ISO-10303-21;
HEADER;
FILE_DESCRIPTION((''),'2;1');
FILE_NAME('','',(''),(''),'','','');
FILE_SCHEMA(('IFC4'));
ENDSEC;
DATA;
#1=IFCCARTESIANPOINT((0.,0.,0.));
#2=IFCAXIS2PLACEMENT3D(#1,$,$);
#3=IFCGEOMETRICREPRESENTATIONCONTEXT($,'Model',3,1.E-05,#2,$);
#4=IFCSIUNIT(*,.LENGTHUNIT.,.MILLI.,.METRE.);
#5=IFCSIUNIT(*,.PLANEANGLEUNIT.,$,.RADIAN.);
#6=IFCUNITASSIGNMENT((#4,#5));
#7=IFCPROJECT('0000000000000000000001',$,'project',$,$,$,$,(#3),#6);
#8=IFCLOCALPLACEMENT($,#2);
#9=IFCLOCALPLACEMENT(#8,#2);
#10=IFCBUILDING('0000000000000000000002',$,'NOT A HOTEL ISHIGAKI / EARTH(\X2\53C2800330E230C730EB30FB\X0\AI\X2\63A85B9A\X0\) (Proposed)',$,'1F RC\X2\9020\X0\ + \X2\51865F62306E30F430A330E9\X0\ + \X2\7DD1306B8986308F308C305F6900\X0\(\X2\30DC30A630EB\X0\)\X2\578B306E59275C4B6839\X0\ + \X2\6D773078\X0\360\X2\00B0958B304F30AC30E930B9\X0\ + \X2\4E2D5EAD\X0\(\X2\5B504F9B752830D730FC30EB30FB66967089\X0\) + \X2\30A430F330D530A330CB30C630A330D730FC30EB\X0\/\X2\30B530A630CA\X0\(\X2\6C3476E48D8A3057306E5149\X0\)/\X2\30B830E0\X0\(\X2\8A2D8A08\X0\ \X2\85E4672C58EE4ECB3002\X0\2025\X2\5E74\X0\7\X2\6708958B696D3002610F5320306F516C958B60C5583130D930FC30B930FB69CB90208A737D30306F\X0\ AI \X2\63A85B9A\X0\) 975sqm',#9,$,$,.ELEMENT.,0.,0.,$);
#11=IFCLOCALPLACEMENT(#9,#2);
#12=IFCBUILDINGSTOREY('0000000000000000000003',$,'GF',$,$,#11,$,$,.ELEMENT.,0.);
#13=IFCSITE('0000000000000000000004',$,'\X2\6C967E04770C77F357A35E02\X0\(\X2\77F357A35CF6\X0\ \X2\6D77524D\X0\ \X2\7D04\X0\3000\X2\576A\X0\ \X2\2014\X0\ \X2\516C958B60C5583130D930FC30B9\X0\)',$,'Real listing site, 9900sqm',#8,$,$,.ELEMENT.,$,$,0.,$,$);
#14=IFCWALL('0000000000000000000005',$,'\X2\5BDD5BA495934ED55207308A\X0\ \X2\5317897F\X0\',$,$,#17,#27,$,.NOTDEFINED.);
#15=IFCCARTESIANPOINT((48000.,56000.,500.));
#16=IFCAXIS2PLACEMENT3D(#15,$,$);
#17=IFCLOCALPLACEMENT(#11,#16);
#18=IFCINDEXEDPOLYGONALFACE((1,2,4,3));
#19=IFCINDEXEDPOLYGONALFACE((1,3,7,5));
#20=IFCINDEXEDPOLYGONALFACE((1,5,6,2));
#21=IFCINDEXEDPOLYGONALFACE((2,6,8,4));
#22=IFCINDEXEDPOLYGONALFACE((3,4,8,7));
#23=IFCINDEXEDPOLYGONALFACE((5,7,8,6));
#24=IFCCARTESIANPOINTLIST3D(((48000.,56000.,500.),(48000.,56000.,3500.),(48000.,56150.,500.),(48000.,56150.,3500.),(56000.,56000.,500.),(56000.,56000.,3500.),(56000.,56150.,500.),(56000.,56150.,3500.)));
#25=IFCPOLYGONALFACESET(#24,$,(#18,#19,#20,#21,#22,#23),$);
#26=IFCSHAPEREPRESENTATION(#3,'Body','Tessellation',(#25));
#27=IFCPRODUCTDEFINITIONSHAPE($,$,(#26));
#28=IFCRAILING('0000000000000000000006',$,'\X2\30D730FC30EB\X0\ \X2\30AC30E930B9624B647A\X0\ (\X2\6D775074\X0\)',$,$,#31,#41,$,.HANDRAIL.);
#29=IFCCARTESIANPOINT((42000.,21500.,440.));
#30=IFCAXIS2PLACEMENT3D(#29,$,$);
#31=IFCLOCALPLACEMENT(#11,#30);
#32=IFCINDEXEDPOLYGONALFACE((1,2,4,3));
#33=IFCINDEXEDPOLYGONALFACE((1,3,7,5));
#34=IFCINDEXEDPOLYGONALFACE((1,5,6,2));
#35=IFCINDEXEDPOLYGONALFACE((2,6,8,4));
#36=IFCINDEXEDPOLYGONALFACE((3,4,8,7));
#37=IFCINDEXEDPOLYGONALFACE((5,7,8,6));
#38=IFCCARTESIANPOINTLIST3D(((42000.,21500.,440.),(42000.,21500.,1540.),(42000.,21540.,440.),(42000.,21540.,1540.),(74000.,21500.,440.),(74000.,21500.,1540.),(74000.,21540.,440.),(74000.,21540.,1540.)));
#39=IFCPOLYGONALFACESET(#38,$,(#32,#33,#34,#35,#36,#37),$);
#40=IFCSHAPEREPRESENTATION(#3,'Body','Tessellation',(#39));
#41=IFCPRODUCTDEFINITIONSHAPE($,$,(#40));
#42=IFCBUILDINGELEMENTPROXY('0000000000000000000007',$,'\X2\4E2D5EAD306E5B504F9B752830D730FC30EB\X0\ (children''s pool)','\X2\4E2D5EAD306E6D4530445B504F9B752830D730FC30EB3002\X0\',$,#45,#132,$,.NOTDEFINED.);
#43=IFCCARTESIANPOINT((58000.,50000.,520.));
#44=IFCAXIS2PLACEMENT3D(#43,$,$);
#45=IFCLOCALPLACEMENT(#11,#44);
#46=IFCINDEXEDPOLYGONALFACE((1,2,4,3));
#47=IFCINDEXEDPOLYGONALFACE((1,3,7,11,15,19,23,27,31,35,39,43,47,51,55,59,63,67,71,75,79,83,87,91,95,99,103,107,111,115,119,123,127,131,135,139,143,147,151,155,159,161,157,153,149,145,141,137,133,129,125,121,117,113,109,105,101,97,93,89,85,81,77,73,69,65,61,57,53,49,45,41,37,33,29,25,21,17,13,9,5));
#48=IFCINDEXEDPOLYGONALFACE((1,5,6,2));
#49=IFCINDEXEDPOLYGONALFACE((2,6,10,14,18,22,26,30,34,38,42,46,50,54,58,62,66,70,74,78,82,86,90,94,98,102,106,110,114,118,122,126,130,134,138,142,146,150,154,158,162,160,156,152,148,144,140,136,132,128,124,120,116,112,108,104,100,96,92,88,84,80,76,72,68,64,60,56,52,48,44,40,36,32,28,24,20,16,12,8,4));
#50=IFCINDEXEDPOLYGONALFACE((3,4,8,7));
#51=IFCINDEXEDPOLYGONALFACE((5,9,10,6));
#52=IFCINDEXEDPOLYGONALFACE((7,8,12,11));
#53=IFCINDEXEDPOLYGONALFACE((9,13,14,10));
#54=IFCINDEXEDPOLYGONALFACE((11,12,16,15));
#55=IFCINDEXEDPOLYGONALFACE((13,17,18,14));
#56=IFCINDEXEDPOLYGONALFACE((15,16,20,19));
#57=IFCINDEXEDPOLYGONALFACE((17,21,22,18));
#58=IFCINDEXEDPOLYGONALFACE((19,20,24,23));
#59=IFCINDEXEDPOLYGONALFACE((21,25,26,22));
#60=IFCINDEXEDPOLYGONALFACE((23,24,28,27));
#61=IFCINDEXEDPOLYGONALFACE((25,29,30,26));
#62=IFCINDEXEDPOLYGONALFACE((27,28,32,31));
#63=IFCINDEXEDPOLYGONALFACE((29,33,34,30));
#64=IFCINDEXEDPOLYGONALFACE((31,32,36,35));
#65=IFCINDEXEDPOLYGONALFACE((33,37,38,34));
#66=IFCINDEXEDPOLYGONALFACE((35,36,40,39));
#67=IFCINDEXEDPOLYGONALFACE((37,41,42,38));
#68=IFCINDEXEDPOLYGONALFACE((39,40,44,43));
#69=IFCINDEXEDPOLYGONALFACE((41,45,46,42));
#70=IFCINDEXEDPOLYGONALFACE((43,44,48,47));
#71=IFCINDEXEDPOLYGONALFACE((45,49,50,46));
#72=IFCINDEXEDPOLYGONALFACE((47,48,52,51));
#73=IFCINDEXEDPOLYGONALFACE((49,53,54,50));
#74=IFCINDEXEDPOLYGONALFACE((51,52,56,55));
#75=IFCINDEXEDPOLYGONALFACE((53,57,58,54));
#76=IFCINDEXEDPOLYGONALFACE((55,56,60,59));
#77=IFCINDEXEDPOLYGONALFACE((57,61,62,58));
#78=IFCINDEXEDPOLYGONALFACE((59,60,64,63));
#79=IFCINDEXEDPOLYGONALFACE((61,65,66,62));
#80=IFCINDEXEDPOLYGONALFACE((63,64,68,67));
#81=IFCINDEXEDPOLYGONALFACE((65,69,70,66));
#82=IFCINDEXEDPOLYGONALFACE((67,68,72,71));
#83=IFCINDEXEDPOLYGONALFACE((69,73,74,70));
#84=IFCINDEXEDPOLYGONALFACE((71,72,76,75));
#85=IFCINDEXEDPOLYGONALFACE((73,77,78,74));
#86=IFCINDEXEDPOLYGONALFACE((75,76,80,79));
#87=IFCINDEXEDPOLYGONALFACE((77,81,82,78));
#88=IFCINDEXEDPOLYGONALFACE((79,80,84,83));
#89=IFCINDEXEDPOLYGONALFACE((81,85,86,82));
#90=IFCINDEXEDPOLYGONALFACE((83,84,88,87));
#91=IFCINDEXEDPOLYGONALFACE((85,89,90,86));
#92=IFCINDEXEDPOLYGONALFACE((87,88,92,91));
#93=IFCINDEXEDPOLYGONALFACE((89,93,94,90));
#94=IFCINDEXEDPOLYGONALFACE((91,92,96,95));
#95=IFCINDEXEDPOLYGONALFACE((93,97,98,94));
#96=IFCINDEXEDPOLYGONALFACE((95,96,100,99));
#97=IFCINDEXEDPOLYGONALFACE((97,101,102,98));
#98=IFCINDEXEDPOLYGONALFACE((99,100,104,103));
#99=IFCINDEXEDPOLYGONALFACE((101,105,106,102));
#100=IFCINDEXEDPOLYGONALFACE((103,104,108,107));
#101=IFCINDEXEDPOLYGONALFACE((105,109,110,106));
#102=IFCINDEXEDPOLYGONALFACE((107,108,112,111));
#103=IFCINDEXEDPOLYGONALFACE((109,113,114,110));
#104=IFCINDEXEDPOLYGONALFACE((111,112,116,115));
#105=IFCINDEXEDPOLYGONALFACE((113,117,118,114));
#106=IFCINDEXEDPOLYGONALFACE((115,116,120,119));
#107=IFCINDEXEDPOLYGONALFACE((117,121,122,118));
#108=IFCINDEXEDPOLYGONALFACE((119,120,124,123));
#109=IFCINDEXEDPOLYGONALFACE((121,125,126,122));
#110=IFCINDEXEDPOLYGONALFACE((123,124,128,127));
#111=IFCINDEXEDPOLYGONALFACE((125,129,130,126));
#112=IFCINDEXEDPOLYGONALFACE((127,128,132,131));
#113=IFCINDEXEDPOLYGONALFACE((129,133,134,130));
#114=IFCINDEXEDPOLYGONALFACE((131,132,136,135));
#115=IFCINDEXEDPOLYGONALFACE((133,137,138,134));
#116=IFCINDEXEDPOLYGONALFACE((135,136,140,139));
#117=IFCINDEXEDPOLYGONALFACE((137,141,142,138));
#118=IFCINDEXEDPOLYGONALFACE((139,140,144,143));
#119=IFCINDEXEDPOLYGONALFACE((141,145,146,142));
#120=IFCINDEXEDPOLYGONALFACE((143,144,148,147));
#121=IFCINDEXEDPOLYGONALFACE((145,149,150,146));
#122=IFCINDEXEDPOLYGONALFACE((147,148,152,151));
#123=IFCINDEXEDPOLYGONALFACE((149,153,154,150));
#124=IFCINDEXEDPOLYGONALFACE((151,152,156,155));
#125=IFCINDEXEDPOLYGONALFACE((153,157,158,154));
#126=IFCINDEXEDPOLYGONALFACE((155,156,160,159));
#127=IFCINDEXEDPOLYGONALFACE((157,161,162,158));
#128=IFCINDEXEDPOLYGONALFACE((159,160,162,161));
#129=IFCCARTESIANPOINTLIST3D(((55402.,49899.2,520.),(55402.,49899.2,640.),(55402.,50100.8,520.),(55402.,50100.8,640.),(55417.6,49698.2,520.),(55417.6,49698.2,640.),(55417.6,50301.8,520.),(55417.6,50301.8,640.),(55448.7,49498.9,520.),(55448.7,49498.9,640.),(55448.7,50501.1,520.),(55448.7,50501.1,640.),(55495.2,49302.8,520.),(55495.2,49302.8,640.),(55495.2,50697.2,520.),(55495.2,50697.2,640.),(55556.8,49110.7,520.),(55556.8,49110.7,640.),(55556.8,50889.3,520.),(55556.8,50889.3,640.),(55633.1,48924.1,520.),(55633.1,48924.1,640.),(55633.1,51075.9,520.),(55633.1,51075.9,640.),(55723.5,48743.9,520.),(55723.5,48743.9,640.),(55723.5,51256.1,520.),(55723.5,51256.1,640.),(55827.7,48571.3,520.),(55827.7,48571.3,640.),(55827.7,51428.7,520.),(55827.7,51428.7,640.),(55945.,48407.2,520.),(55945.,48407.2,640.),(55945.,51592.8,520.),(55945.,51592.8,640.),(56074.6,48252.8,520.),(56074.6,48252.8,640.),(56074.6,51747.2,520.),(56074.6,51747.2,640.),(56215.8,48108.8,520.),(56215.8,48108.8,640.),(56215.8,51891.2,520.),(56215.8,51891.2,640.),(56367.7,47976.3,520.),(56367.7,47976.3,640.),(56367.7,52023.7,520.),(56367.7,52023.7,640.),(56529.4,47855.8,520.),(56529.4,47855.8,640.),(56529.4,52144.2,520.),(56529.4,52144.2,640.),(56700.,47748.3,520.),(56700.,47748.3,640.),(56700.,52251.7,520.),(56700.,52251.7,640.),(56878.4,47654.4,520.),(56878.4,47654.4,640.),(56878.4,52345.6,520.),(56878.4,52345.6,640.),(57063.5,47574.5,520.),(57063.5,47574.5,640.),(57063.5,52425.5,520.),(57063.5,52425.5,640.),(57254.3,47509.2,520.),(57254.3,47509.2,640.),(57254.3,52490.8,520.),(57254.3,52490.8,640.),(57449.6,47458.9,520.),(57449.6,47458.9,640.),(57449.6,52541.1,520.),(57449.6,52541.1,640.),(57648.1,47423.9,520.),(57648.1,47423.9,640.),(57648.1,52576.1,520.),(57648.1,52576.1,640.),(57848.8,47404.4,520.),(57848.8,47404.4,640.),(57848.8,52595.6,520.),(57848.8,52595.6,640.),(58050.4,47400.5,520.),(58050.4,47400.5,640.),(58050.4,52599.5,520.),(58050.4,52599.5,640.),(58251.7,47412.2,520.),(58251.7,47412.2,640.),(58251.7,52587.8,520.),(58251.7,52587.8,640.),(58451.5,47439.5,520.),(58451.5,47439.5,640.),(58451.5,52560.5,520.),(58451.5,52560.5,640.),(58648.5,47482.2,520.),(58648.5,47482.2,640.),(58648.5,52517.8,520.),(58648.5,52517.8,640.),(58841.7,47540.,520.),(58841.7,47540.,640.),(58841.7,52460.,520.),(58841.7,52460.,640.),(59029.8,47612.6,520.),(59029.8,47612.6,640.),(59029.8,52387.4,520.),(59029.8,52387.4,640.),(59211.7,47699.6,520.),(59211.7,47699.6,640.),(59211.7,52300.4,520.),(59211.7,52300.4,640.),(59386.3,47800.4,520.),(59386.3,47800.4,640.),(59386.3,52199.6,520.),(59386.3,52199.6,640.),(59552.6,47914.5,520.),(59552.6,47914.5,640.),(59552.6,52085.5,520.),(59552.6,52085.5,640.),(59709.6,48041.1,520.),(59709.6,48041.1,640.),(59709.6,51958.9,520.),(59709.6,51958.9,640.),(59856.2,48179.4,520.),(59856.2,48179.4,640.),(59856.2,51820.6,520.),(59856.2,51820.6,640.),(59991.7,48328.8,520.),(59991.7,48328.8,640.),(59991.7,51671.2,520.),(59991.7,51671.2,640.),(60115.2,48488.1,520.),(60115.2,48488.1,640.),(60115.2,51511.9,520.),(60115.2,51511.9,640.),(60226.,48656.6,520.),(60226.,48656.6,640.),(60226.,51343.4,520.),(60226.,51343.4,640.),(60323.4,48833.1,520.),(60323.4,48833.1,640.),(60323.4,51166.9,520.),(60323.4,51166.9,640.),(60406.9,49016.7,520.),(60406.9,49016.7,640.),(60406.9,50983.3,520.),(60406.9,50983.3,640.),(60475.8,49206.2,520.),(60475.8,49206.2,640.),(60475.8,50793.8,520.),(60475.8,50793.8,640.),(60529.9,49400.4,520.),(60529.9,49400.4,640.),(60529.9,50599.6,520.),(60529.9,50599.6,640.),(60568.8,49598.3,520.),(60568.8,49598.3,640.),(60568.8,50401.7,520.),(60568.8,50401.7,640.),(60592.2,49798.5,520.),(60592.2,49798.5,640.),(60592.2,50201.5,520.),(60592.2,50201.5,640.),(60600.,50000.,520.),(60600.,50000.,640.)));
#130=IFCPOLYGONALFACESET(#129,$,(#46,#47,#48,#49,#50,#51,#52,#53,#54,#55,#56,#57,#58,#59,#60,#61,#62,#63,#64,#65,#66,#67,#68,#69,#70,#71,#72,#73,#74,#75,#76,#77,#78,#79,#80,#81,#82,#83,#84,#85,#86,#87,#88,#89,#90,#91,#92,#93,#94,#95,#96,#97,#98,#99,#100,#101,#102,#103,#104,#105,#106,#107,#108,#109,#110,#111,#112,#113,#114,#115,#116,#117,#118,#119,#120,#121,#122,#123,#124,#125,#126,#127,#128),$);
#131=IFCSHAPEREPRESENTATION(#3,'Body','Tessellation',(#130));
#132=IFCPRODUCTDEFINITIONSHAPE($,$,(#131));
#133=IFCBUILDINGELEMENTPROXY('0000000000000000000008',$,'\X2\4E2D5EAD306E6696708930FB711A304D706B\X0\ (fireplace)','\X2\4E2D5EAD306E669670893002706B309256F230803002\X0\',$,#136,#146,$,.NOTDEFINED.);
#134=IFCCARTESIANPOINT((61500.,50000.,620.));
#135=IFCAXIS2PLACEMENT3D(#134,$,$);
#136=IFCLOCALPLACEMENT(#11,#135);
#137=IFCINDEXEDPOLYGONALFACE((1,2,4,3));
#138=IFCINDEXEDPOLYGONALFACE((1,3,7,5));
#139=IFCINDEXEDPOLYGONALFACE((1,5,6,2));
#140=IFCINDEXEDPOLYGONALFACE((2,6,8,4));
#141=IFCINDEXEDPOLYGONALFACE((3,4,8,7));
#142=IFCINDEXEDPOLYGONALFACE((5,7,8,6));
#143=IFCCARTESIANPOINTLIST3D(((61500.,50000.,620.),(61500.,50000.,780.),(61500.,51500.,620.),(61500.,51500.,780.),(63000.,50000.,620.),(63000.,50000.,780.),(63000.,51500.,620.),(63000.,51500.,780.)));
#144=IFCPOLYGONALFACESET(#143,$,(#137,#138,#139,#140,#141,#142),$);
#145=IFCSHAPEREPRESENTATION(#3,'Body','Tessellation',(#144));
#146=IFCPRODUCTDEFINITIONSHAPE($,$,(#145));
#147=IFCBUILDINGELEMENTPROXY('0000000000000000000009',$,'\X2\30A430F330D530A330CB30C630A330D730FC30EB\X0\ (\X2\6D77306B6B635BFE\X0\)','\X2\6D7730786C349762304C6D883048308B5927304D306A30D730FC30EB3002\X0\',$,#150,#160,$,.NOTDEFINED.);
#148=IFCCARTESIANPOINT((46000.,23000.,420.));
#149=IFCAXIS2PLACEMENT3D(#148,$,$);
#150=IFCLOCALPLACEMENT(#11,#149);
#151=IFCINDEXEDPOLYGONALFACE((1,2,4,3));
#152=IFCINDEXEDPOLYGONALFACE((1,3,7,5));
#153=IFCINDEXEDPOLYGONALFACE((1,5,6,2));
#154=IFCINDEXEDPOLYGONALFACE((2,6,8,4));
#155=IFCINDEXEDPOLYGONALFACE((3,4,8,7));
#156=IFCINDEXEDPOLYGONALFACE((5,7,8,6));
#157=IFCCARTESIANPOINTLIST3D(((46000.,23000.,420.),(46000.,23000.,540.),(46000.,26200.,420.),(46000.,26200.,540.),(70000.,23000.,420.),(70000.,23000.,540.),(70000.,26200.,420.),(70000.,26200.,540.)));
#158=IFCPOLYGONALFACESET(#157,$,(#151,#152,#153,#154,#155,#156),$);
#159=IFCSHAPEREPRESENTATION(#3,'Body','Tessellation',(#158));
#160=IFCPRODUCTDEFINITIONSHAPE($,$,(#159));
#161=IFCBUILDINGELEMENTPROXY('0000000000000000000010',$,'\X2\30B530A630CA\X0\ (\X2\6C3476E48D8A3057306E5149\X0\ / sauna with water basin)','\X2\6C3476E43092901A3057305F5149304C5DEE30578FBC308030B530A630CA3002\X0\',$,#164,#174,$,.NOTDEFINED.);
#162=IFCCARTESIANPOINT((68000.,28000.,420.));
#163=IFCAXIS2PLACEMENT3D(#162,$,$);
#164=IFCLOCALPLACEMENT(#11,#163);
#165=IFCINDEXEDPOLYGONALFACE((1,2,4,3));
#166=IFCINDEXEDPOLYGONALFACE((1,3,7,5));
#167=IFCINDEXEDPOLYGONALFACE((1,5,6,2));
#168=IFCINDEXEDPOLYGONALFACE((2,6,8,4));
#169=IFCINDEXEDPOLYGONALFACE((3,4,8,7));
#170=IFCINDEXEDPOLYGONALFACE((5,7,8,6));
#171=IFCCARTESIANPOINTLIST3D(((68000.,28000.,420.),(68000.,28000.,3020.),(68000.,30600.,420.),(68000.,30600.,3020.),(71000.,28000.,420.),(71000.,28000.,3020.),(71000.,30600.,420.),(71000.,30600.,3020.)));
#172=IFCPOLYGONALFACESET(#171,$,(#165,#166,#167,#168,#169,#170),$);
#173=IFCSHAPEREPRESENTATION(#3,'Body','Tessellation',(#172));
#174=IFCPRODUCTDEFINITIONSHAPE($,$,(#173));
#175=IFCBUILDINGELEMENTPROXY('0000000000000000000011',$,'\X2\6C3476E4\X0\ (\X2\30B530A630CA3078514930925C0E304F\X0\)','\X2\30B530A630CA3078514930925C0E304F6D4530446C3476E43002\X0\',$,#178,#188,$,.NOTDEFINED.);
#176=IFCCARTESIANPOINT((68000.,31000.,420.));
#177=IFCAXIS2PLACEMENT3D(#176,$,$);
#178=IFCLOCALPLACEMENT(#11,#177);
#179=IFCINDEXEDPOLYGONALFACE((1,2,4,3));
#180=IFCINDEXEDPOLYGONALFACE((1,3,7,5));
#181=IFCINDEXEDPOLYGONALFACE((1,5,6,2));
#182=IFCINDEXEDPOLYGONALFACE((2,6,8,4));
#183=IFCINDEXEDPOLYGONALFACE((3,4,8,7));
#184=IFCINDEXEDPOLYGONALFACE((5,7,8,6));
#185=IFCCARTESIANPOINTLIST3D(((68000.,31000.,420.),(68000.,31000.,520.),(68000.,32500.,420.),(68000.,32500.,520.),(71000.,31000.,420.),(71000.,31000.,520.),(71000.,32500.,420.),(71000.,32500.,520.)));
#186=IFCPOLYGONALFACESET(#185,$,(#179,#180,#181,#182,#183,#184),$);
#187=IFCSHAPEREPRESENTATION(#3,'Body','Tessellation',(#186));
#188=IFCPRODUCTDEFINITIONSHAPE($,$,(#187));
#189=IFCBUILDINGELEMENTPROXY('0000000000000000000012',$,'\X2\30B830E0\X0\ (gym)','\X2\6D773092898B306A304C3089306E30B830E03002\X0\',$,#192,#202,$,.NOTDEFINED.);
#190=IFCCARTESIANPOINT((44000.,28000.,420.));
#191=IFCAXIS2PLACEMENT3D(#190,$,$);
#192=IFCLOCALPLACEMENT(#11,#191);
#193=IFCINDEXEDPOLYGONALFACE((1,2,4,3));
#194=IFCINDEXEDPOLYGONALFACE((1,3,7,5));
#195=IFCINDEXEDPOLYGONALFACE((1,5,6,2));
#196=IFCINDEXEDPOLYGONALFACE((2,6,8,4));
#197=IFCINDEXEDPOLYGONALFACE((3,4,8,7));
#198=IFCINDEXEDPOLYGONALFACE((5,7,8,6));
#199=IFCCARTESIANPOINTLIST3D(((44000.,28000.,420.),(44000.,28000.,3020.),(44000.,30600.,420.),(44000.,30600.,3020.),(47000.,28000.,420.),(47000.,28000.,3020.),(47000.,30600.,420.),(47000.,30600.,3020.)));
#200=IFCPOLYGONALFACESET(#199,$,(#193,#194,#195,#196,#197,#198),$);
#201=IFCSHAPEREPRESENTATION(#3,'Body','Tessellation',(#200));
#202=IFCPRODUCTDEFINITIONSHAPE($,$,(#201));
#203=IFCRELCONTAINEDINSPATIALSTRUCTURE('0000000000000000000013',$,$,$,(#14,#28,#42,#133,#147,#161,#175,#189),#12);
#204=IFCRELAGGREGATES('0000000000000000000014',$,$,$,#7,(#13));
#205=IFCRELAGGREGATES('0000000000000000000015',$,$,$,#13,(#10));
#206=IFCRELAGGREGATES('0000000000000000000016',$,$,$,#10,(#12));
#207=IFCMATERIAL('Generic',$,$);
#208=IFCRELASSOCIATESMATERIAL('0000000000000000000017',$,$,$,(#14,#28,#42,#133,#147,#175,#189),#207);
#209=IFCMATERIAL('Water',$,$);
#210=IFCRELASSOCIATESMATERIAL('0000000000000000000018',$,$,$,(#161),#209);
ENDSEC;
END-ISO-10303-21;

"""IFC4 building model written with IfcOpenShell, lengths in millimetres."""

from ifc_helpers import new_model, si_unit, frame, frame_2d, origin, origin_2d, place, context, project, spatial, rectangle, circle, extrude, material, element, save


model = new_model("IFC4")

# Units and contexts
model_context = context("Model", 3, precision=1e-05, world=origin())
ifc_project = project(units=[si_unit("LENGTHUNIT", "METRE", prefix="MILLI"), si_unit("PLANEANGLEUNIT", "RADIAN")], contexts=[model_context])

# Site, building, storey
site_placement = place(None, origin())
site = spatial("IfcSite", under=ifc_project, at=site_placement, Name="沖縄県石垣市(石垣島 海前 約3000坪 — 公開情報ベース)", ObjectType="Real listing site, 9900sqm", CompositionType="ELEMENT", RefElevation=0.0)
building_placement = place(site_placement, origin())
building = spatial("IfcBuilding", under=site, at=building_placement, Name="NOT A HOTEL ISHIGAKI / EARTH(参考モデル・AI推定) (Proposed)", ObjectType="1F RC造 + 円形のヴィラ + 緑に覆われた椀(ボウル)型の大屋根 + 海へ360°開くガラス + 中庭(子供用プール・暖炉) + インフィニティプール/サウナ(水盤越しの光)/ジム(設計 藤本壮介。2025年7月開業。意匠は公開情報ベース・構造詳細は AI 推定) 975sqm", CompositionType="ELEMENT", ElevationOfRefHeight=0.0, ElevationOfTerrain=0.0)
storey_placement = place(building_placement, origin())
storey = spatial("IfcBuildingStorey", under=building, at=storey_placement, Name="GF", CompositionType="ELEMENT", Elevation=0.0)

# Shared definitions
ifc_material_1 = material(Name="Generic")

# Wall
wall_1_placement = place(storey_placement, frame((48000.0, 56000.0, 500.0)))
element("IfcWall", 1, at=wall_1_placement, inside=storey, material=ifc_material_1, Name="寝室間仕切り 北西", PredefinedType="NOTDEFINED", context=model_context, shape_type="SweptSolid", body=[
    extrude(rectangle(XDim=8000.0, YDim=150.0, at=frame_2d((4000.0, 75.0))), frame((48000.0, 56000.0, 500.0)), (0.0, 0.0, 1.0), 3000.0),
])

# Railing
railing_placement = place(storey_placement, frame((42000.0, 21500.0, 440.0)))
element("IfcRailing", 2, at=railing_placement, inside=storey, material=ifc_material_1, Name="プール ガラス手摺 (海側)", PredefinedType="HANDRAIL", context=model_context, shape_type="SweptSolid", body=[
    extrude(rectangle(XDim=32000.0, YDim=40.0, at=frame_2d((16000.0, 20.0))), frame((42000.0, 21500.0, 440.0)), (0.0, 0.0, 1.0), 1100.0),
])

# Building element proxies
proxy_1_placement = place(storey_placement, frame((58000.0, 50000.0, 520.0)))
element("IfcBuildingElementProxy", 3, at=proxy_1_placement, inside=storey, material=ifc_material_1, Name="中庭の子供用プール (children's pool)", Description="中庭の浅い子供用プール。", PredefinedType="NOTDEFINED", context=model_context, shape_type="SweptSolid", body=[
    extrude(circle(Radius=2600.0, at=origin_2d()), frame((58000.0, 50000.0, 520.0)), (0.0, 0.0, 1.0), 120.0),
])
proxy_2_placement = place(storey_placement, frame((61500.0, 50000.0, 620.0)))
element("IfcBuildingElementProxy", 4, at=proxy_2_placement, inside=storey, material=ifc_material_1, Name="中庭の暖炉・焚き火 (fireplace)", Description="中庭の暖炉。火を囲む。", PredefinedType="NOTDEFINED", context=model_context, shape_type="SweptSolid", body=[
    extrude(rectangle(XDim=1500.0, YDim=1500.0, at=frame_2d((750.0, 750.0))), frame((61500.0, 50000.0, 620.0)), (0.0, 0.0, 1.0), 160.0),
])
proxy_3_placement = place(storey_placement, frame((46000.0, 23000.0, 420.0)))
element("IfcBuildingElementProxy", 5, at=proxy_3_placement, inside=storey, material=ifc_material_1, Name="インフィニティプール (海に正対)", Description="海へ水面が消える大きなプール。", PredefinedType="NOTDEFINED", context=model_context, shape_type="SweptSolid", body=[
    extrude(rectangle(XDim=24000.0, YDim=3200.0, at=frame_2d((12000.0, 1600.0))), frame((46000.0, 23000.0, 420.0)), (0.0, 0.0, 1.0), 120.0),
])
ifc_material_2 = material(Name="Water")
proxy_4_placement = place(storey_placement, frame((68000.0, 28000.0, 420.0)))
element("IfcBuildingElementProxy", 6, at=proxy_4_placement, inside=storey, material=ifc_material_2, Name="サウナ (水盤越しの光 / sauna with water basin)", Description="水盤を通した光が差し込むサウナ。", PredefinedType="NOTDEFINED", context=model_context, shape_type="SweptSolid", body=[
    extrude(rectangle(XDim=3000.0, YDim=2600.0, at=frame_2d((1500.0, 1300.0))), frame((68000.0, 28000.0, 420.0)), (0.0, 0.0, 1.0), 2600.0),
])
proxy_5_placement = place(storey_placement, frame((68000.0, 31000.0, 420.0)))
element("IfcBuildingElementProxy", 7, at=proxy_5_placement, inside=storey, material=ifc_material_1, Name="水盤 (サウナへ光を導く)", Description="サウナへ光を導く浅い水盤。", PredefinedType="NOTDEFINED", context=model_context, shape_type="SweptSolid", body=[
    extrude(rectangle(XDim=3000.0, YDim=1500.0, at=frame_2d((1500.0, 750.0))), frame((68000.0, 31000.0, 420.0)), (0.0, 0.0, 1.0), 100.0),
])
proxy_6_placement = place(storey_placement, frame((44000.0, 28000.0, 420.0)))
element("IfcBuildingElementProxy", 8, at=proxy_6_placement, inside=storey, material=ifc_material_1, Name="ジム (gym)", Description="海を見ながらのジム。", PredefinedType="NOTDEFINED", context=model_context, shape_type="SweptSolid", body=[
    extrude(rectangle(XDim=3000.0, YDim=2600.0, at=frame_2d((1500.0, 1300.0))), frame((44000.0, 28000.0, 420.0)), (0.0, 0.0, 1.0), 2600.0),
])

save(model, "model.ifc")
